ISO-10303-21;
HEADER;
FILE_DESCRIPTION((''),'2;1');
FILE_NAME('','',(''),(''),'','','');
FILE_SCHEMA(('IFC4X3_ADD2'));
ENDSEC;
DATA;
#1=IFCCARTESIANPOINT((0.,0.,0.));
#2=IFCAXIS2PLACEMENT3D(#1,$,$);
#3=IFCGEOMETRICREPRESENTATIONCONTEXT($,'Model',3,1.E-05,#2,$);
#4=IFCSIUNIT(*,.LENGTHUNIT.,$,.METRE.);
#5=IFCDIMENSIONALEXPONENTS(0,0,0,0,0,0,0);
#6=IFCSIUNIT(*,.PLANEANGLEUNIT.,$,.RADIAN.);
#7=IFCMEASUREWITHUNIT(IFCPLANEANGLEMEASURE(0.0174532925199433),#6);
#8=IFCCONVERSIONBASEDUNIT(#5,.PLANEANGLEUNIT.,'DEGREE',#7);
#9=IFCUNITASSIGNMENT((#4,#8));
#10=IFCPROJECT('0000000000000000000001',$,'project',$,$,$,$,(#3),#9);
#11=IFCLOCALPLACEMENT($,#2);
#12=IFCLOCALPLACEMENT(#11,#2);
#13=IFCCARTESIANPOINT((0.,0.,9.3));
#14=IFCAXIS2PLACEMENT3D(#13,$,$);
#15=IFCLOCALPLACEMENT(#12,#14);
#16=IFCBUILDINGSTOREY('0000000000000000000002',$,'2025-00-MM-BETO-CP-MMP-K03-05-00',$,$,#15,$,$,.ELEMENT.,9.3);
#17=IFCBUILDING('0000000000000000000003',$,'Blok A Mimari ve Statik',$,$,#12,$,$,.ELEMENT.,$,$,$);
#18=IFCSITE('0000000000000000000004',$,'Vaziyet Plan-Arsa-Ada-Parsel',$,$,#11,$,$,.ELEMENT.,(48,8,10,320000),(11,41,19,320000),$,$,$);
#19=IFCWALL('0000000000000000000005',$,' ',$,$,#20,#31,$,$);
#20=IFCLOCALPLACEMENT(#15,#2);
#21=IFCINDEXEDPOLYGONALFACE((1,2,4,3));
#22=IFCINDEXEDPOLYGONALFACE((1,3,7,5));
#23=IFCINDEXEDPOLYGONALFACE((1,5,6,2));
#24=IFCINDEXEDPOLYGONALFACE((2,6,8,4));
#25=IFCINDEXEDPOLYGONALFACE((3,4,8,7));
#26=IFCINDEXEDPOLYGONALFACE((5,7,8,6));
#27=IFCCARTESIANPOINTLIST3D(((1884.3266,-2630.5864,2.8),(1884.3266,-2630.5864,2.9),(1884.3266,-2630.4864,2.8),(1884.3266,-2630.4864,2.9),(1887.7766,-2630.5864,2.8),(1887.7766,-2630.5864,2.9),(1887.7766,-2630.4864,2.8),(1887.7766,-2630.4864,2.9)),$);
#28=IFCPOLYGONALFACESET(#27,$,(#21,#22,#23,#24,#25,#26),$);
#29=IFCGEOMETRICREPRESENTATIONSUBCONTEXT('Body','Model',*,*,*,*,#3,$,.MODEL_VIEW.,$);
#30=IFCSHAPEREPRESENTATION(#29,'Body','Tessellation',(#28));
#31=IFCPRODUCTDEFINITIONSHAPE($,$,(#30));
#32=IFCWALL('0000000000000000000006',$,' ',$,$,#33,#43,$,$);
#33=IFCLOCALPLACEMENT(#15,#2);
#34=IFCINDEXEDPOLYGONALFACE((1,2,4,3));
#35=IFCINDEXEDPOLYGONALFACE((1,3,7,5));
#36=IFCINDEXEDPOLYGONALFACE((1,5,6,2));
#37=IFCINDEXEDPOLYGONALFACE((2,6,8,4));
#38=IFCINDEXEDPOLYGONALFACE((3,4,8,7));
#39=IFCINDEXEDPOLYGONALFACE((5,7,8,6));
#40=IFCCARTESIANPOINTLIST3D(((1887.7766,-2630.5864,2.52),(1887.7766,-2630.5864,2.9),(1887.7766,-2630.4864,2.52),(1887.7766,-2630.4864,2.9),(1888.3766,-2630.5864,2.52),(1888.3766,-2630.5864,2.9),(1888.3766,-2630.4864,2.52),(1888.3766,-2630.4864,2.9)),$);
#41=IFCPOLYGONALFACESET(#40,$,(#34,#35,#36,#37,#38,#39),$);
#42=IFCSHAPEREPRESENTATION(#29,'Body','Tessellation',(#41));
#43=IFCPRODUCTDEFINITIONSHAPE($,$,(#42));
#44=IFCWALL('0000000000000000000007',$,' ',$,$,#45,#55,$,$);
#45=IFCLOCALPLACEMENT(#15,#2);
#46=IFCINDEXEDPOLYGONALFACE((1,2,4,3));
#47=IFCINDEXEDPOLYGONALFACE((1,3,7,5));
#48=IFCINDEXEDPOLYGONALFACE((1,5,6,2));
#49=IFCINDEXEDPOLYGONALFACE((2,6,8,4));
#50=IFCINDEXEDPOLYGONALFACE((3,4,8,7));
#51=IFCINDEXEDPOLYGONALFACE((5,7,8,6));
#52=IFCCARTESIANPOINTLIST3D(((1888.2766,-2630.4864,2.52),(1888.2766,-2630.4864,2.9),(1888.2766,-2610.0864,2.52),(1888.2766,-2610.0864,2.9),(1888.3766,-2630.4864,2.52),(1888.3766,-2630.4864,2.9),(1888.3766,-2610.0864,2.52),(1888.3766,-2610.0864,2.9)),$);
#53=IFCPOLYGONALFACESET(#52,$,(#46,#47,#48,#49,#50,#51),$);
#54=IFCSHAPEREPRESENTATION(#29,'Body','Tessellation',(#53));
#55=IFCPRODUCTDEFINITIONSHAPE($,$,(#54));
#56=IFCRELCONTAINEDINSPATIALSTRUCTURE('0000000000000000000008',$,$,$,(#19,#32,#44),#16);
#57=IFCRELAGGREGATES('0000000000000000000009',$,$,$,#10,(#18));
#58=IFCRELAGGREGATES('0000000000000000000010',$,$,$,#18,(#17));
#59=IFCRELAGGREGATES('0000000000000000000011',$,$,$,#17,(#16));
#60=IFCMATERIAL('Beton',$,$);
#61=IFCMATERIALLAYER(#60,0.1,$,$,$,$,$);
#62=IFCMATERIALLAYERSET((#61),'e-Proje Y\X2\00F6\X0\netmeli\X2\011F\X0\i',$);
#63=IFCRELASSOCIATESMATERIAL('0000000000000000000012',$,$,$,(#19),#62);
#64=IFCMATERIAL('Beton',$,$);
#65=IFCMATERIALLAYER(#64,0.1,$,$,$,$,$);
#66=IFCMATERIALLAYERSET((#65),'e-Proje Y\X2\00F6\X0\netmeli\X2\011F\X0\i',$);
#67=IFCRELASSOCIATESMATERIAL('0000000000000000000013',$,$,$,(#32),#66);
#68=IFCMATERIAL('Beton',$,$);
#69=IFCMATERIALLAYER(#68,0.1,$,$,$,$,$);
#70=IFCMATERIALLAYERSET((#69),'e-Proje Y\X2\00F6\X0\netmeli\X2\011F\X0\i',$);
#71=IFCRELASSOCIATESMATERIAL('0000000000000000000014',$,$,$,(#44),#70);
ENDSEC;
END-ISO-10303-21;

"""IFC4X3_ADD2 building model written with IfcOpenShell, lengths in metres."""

from ifc_helpers import new_model, entity, si_unit, converted_unit, frame, frame_2d, origin, origin_with_axes, place, context, subcontext, project, spatial, rectangle, extrude, material, layer, layer_set, layer_usage, element, save


model = new_model("IFC4X3_ADD2")

# Units and contexts
model_context = context("Model", 3, precision=1e-05, world=origin())
body_context = subcontext(model_context, "Body", "Model", "MODEL_VIEW")
ifc_project = project(units=[si_unit("LENGTHUNIT", "METRE"), converted_unit("PLANEANGLEUNIT", "DEGREE", entity("IfcPlaneAngleMeasure", 0.0174532925199433), si_unit("PLANEANGLEUNIT", "RADIAN"), dimensions=[0, 0, 0, 0, 0, 0, 0])], contexts=[model_context])

# Site, building, storey
site_placement = place(None, origin())
site = spatial("IfcSite", under=ifc_project, at=site_placement, Name="Vaziyet Plan-Arsa-Ada-Parsel", CompositionType="ELEMENT", RefLatitude=(48, 8, 10, 320000), RefLongitude=(11, 41, 19, 320000))
building_placement = place(site_placement, origin())
building = spatial("IfcBuilding", under=site, at=building_placement, Name="Blok A Mimari ve Statik", CompositionType="ELEMENT")
storey_placement = place(building_placement, frame((0.0, 0.0, 9.3)))
storey = spatial("IfcBuildingStorey", under=building, at=storey_placement, Name="2025-00-MM-BETO-CP-MMP-K03-05-00", CompositionType="ELEMENT", Elevation=9.3)

# Walls
ifc_material_1 = material(Name="Beton")
ifc_layer_1 = layer(ifc_material_1, 0.1)
ifc_layer_set_1 = layer_set([ifc_layer_1], Name="e-Proje Yönetmeliği")
ifc_layer_usage_1 = layer_usage(ifc_layer_set_1, "AXIS2", "POSITIVE", 0.0)
wall_1_placement = place(storey_placement, frame((1884.3266, -2630.5864, 2.8), z_axis=(0.0, 0.0, 1.0), x_axis=(1.0, 0.0, 0.0)))
element("IfcWall", 1, at=wall_1_placement, inside=storey, material=ifc_layer_usage_1, Name=" ", context=body_context, shape_type="SweptSolid", body=[
    extrude(rectangle(XDim=3.45, YDim=0.1, at=frame_2d((1.725, 0.05), x_axis=(1.0, 0.0))), origin_with_axes(), (0.0, 0.0, 1.0), 0.1),
])
ifc_material_2 = material(Name="Beton")
ifc_layer_2 = layer(ifc_material_2, 0.1)
ifc_layer_set_2 = layer_set([ifc_layer_2], Name="e-Proje Yönetmeliği")
ifc_layer_usage_2 = layer_usage(ifc_layer_set_2, "AXIS2", "POSITIVE", 0.0)
wall_2_placement = place(storey_placement, frame((1887.7766, -2630.5864, 2.52)))
element("IfcWall", 2, at=wall_2_placement, inside=storey, material=ifc_layer_usage_2, Name=" ", context=body_context, shape_type="SweptSolid", body=[
    extrude(rectangle(XDim=0.6, YDim=0.1, at=frame_2d((0.3, 0.05), x_axis=(1.0, 0.0))), origin_with_axes(), (0.0, 0.0, 1.0), 0.38),
])
ifc_material_3 = material(Name="Beton")
ifc_layer_3 = layer(ifc_material_3, 0.1)
ifc_layer_set_3 = layer_set([ifc_layer_3], Name="e-Proje Yönetmeliği")
ifc_layer_usage_3 = layer_usage(ifc_layer_set_3, "AXIS2", "POSITIVE", 0.0)
wall_3_placement = place(storey_placement, frame((1888.3766, -2630.4864, 2.52), z_axis=(0.0, 0.0, 1.0), x_axis=(0.0, 1.0, 0.0)))
element("IfcWall", 3, at=wall_3_placement, inside=storey, material=ifc_layer_usage_3, Name=" ", context=body_context, shape_type="SweptSolid", body=[
    extrude(rectangle(XDim=20.4, YDim=0.1, at=frame_2d((10.2, 0.05), x_axis=(1.0, 0.0))), origin_with_axes(), (0.0, 0.0, 1.0), 0.38),
])

save(model, "model.ifc")
